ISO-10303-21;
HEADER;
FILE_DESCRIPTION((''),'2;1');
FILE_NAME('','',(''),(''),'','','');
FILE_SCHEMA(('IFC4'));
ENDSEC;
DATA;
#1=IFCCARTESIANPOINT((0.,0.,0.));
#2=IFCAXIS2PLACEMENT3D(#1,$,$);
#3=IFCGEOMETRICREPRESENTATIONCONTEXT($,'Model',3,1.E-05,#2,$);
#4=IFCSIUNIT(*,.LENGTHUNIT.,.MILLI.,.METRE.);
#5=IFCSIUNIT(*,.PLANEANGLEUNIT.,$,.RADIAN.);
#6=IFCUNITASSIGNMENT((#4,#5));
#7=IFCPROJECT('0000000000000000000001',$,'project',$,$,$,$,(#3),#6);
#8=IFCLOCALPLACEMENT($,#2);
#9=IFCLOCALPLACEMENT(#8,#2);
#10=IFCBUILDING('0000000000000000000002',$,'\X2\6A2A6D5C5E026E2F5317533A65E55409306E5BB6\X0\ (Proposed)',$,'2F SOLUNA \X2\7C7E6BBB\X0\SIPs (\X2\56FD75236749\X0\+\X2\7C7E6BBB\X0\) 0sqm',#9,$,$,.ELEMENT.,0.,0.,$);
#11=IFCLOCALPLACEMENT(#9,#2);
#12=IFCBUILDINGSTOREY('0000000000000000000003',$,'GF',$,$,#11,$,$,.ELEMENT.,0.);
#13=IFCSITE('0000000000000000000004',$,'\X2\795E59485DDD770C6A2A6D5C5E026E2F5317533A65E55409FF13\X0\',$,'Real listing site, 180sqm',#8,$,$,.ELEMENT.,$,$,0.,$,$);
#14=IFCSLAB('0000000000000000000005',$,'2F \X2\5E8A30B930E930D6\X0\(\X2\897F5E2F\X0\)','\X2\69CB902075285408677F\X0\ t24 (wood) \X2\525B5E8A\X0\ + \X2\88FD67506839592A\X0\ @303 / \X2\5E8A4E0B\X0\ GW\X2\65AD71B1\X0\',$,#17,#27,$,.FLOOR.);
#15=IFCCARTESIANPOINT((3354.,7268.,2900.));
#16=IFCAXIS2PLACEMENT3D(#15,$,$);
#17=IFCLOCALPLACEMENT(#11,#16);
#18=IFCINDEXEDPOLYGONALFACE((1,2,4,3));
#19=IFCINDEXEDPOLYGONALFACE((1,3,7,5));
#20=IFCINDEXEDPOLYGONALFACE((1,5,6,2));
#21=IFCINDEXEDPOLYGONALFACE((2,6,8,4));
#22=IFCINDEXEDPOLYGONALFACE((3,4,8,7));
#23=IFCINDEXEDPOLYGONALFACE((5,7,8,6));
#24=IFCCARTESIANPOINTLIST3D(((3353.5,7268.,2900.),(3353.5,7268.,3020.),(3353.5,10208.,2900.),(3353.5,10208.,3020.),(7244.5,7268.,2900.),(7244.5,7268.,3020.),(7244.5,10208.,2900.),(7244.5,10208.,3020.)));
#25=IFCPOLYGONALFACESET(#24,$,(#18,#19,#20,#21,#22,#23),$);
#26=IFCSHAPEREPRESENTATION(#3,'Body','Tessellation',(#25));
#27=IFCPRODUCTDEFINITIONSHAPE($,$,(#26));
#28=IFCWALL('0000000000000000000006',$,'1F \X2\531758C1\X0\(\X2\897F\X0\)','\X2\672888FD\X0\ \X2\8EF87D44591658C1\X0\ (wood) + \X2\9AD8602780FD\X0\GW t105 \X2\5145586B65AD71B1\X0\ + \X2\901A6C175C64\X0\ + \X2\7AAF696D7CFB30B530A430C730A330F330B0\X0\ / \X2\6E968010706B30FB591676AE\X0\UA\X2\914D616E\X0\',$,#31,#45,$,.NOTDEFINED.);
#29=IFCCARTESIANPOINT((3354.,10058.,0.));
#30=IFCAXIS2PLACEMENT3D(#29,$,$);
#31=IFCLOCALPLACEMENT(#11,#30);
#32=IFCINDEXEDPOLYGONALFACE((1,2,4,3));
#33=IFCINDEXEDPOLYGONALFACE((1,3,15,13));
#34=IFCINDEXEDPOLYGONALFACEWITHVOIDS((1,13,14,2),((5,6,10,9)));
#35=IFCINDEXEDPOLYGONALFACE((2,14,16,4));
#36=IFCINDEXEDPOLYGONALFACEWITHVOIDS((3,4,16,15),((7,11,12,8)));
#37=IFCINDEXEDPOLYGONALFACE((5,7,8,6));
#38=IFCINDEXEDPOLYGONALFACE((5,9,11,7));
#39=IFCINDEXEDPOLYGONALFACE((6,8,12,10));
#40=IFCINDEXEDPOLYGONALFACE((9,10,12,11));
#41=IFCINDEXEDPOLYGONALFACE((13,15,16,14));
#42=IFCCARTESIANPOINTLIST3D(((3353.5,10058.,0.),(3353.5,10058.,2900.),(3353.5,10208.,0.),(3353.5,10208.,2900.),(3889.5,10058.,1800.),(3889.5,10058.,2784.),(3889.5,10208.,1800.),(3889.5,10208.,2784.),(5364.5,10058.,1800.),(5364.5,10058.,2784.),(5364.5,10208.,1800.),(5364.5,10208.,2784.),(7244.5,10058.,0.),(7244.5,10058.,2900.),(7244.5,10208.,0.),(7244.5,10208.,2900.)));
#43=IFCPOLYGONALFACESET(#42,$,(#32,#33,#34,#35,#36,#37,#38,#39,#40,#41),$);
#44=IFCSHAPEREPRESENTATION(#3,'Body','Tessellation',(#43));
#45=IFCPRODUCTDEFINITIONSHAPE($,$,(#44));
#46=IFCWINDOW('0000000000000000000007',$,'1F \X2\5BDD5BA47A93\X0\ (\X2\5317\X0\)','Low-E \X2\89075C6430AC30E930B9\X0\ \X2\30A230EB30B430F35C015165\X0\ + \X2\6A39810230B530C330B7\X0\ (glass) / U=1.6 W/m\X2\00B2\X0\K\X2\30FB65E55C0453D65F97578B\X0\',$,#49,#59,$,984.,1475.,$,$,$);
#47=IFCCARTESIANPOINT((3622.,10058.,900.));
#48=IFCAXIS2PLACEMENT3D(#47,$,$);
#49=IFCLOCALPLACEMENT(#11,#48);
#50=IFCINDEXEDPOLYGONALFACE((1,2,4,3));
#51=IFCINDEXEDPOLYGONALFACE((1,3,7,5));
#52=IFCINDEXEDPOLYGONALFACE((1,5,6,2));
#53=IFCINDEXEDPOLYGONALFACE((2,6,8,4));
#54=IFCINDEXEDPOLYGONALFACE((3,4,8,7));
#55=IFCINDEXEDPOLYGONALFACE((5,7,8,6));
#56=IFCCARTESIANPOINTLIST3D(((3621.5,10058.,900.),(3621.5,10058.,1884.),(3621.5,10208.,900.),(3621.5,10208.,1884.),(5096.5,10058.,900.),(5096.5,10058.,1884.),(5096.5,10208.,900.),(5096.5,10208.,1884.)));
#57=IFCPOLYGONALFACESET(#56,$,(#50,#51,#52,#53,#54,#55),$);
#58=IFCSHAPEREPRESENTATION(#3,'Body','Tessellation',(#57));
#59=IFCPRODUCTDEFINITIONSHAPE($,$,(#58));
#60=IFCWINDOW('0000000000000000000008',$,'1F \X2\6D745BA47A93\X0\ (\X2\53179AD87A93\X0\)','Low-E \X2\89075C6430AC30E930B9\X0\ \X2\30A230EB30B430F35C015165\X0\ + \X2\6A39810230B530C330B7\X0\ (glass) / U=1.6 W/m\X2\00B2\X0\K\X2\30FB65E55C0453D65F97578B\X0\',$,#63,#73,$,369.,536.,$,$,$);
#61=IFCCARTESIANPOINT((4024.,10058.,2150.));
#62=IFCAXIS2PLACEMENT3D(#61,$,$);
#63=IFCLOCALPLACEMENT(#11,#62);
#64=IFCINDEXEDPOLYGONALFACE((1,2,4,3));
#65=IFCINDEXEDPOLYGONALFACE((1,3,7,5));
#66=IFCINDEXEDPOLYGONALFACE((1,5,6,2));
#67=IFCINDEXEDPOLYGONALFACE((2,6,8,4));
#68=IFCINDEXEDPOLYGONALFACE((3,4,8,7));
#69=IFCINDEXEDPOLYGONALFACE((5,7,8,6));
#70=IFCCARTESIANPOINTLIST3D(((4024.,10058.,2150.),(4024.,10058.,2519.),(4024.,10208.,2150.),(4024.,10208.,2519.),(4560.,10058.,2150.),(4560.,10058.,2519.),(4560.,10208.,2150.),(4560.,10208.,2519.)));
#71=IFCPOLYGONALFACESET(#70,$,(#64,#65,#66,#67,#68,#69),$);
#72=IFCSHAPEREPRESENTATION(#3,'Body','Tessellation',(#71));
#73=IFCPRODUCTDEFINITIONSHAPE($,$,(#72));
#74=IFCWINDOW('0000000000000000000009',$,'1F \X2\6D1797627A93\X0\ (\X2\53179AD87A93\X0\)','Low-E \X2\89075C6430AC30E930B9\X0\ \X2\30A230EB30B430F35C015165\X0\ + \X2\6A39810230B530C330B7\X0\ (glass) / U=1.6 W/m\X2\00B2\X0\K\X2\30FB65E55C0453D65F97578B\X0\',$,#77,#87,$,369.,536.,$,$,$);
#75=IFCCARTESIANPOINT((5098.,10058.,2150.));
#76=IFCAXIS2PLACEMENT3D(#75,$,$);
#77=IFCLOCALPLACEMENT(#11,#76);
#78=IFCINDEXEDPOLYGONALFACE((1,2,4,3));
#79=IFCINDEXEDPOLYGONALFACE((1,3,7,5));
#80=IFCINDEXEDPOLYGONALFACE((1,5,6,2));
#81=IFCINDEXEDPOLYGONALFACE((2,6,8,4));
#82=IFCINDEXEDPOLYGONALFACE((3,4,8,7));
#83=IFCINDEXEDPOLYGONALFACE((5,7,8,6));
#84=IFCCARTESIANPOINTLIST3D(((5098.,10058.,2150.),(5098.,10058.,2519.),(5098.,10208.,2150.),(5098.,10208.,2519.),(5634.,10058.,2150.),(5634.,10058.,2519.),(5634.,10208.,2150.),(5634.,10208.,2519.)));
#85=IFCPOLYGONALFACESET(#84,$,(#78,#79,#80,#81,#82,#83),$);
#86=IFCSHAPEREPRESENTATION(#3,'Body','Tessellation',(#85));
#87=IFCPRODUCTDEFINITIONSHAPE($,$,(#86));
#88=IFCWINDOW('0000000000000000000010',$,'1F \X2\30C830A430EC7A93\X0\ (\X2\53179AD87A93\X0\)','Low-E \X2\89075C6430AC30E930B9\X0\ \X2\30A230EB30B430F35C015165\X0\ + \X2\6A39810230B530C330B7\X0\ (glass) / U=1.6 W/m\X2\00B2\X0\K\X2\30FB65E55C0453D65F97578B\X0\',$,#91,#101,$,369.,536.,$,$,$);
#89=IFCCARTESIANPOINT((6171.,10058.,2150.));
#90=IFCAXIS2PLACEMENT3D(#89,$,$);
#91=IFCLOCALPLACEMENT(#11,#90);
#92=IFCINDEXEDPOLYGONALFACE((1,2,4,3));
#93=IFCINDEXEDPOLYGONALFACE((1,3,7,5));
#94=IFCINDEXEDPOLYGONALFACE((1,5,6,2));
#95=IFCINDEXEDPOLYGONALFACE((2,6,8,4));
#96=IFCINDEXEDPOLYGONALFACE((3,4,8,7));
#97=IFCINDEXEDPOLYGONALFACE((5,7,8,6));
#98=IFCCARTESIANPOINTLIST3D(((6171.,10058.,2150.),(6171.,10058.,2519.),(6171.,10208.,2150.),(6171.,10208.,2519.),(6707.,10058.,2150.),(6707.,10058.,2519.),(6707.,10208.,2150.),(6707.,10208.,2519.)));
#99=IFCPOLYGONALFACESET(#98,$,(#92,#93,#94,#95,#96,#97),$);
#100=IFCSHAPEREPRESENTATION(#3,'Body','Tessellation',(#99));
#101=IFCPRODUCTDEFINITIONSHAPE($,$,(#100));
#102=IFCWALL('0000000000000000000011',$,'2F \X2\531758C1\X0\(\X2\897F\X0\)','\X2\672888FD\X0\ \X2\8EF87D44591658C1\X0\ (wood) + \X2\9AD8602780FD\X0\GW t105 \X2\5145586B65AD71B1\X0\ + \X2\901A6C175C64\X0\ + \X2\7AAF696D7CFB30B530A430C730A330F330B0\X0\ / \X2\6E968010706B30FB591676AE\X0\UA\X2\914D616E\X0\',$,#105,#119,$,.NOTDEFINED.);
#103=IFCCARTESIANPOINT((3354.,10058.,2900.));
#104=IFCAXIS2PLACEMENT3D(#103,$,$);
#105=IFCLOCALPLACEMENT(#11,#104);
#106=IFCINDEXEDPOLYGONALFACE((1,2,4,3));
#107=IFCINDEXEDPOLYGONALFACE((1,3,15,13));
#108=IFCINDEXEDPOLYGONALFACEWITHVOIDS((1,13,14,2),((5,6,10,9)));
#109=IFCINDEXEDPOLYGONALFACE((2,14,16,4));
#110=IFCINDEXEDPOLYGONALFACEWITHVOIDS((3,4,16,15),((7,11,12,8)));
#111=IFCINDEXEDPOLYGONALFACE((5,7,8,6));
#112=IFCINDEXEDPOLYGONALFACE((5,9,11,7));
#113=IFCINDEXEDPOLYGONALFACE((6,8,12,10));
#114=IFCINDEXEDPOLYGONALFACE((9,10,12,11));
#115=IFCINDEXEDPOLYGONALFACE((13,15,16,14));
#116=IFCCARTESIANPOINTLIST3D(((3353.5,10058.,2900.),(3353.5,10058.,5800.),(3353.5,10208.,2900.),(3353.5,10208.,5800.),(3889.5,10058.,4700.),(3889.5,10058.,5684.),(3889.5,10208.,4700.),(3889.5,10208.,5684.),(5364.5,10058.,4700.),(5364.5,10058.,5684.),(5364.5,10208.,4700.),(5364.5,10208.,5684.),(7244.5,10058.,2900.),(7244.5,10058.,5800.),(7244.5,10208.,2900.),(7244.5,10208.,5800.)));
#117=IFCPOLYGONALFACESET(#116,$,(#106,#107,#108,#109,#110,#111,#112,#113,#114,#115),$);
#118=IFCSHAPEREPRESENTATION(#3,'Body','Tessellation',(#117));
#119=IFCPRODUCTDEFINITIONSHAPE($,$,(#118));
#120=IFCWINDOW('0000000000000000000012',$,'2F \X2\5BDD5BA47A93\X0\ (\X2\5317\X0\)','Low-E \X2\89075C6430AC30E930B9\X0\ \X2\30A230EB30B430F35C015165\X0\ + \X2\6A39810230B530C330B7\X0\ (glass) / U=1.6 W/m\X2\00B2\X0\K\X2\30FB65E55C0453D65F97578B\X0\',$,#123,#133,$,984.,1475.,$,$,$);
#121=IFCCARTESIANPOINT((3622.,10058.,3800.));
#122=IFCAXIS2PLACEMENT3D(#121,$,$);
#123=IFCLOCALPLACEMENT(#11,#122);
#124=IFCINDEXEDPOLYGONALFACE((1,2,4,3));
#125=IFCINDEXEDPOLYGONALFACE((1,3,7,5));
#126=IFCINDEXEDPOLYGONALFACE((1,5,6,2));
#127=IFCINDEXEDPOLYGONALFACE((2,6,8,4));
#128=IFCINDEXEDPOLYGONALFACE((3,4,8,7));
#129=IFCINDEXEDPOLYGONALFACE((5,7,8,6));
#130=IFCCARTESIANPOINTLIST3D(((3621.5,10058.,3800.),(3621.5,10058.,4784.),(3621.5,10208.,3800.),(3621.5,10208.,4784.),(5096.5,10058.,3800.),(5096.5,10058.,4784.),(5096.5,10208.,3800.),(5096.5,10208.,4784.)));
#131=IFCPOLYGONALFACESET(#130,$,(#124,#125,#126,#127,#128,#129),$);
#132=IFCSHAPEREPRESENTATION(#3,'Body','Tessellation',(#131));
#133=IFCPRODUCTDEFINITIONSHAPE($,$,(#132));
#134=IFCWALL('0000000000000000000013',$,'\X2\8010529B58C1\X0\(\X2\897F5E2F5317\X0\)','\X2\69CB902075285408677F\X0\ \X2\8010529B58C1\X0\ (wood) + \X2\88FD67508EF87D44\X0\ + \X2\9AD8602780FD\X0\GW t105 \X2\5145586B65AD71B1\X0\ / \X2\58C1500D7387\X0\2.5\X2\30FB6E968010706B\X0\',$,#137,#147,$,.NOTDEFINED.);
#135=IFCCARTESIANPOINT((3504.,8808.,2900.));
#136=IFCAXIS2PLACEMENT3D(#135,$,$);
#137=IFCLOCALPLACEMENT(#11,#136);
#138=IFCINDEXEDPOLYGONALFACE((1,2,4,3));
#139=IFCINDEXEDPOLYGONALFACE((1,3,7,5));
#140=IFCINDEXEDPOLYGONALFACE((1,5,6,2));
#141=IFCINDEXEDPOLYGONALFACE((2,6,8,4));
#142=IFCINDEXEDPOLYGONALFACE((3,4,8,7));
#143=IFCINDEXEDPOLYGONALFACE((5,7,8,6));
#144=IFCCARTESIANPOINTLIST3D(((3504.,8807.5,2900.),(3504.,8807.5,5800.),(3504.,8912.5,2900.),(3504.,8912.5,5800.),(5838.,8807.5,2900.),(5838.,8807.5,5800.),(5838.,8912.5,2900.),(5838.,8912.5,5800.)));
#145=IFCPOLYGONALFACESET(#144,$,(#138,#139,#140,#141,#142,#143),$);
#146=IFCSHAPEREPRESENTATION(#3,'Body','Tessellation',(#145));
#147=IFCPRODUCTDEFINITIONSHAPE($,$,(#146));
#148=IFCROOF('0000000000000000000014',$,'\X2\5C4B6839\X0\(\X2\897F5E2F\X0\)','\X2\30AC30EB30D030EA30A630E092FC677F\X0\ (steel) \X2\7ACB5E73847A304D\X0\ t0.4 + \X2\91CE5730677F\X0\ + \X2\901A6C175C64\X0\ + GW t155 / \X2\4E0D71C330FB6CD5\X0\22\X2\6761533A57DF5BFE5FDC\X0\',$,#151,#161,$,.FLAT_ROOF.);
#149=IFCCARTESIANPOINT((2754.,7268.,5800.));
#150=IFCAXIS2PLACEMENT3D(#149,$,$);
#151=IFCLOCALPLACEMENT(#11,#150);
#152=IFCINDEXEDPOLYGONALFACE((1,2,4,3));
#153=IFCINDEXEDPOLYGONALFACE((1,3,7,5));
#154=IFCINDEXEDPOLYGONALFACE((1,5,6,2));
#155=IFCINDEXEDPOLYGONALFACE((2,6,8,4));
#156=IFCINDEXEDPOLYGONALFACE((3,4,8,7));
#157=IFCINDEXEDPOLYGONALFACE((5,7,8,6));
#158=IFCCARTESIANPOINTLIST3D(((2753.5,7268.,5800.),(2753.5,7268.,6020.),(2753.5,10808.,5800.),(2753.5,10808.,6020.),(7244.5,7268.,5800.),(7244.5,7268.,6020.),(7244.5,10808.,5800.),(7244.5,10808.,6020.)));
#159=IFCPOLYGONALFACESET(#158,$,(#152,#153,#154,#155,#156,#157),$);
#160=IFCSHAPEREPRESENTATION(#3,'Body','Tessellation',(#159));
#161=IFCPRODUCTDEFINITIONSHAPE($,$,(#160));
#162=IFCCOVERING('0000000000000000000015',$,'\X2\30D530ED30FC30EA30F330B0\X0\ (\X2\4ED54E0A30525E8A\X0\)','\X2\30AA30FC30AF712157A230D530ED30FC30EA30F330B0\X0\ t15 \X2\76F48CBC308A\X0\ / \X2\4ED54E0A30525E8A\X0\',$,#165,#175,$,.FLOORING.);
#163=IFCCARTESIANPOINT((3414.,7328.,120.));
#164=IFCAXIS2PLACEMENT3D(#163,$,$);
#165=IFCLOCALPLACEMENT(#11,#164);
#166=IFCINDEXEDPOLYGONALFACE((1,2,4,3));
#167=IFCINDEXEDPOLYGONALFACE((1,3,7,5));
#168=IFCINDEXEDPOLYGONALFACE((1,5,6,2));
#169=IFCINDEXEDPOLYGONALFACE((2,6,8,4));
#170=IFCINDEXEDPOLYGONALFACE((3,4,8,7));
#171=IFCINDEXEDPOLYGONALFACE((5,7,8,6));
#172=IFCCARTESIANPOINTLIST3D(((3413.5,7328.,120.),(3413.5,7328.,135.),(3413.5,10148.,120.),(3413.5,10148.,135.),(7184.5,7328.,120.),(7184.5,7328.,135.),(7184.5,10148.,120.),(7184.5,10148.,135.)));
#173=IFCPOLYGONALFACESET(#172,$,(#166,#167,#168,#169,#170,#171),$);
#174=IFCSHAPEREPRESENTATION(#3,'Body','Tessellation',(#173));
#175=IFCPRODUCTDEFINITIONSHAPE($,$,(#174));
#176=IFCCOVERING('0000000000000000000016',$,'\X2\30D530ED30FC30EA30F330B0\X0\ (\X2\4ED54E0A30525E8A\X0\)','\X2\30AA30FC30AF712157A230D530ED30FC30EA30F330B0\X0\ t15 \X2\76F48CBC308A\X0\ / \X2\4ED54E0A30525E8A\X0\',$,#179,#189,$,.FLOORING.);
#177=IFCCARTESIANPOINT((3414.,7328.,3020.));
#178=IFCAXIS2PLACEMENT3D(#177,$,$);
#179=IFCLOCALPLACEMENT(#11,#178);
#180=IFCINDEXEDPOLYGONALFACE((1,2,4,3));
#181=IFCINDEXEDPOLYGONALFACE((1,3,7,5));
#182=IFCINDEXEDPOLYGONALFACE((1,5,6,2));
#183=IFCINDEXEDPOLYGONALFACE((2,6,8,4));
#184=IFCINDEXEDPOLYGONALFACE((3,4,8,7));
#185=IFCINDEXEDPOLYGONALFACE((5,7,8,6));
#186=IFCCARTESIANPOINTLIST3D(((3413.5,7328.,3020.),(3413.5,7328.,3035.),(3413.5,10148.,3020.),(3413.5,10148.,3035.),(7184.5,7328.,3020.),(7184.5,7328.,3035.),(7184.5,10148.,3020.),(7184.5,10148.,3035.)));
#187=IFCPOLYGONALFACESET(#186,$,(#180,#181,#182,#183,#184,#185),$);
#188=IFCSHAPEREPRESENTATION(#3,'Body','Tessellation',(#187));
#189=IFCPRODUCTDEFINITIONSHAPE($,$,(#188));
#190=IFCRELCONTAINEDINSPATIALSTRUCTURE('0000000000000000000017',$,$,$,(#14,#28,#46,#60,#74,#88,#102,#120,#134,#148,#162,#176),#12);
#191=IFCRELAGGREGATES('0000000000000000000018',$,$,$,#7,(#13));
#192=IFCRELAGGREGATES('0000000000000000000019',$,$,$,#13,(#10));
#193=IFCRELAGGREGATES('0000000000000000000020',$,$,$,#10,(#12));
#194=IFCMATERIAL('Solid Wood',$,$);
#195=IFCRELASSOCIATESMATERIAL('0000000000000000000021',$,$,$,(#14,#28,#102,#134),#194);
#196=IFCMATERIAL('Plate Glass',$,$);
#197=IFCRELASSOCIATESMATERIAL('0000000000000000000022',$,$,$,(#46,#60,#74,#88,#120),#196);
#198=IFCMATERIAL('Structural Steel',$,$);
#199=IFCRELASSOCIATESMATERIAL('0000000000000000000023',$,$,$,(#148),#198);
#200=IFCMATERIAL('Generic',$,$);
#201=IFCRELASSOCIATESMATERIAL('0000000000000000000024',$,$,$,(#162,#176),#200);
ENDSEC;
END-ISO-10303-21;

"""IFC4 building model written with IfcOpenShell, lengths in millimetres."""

from ifc_helpers import new_model, si_unit, frame, frame_2d, origin, place, context, project, spatial, rectangle, extrude, material, element, fill, save


model = new_model("IFC4")

# Units and contexts
model_context = context("Model", 3, precision=1e-05, world=origin())
ifc_project = project(units=[si_unit("LENGTHUNIT", "METRE", prefix="MILLI"), si_unit("PLANEANGLEUNIT", "RADIAN")], contexts=[model_context])

# Site, building, storey
site_placement = place(None, origin())
site = spatial("IfcSite", under=ifc_project, at=site_placement, Name="神奈川県横浜市港北区日吉３", ObjectType="Real listing site, 180sqm", CompositionType="ELEMENT", RefElevation=0.0)
building_placement = place(site_placement, origin())
building = spatial("IfcBuilding", under=site, at=building_placement, Name="横浜市港北区日吉の家 (Proposed)", ObjectType="2F SOLUNA 籾殻SIPs (国産杉+籾殻) 0sqm", CompositionType="ELEMENT", ElevationOfRefHeight=0.0, ElevationOfTerrain=0.0)
storey_placement = place(building_placement, origin())
storey = spatial("IfcBuildingStorey", under=building, at=storey_placement, Name="GF", CompositionType="ELEMENT", Elevation=0.0)

# Slab
ifc_material_1 = material(Name="Solid Wood")
slab_1_placement = place(storey_placement, frame((3354.0, 7268.0, 2900.0)))
element("IfcSlab", 1, at=slab_1_placement, inside=storey, material=ifc_material_1, Name="2F 床スラブ(西帯)", Description="構造用合板 t24 (wood) 剛床 + 製材根太 @303 / 床下 GW断熱", PredefinedType="FLOOR", context=model_context, shape_type="SweptSolid", body=[
    extrude(rectangle(XDim=3891.0, YDim=2940.0, at=frame_2d((1945.0, 1470.0))), frame((3354.0, 7268.0, 2900.0)), (0.0, 0.0, 1.0), 120.0),
])

# Wall, openings, windows
wall_1_placement = place(storey_placement, frame((3354.0, 10058.0, 0.0)))
wall_1 = element("IfcWall", 2, at=wall_1_placement, inside=storey, material=ifc_material_1, Name="1F 北壁(西)", Description="木製 軸組外壁 (wood) + 高性能GW t105 充填断熱 + 通気層 + 窯業系サイディング / 準耐火・外皮UA配慮", PredefinedType="NOTDEFINED", context=model_context, shape_type="SweptSolid", body=[
    extrude(rectangle(XDim=3891.0, YDim=150.0, at=frame_2d((1945.0, 75.0))), frame((3354.0, 10058.0, 0.0)), (0.0, 0.0, 1.0), 2900.0),
])
opening_1_placement = place(storey_placement, frame((3622.0, 10058.0, 900.0)))
opening_1 = element("IfcOpeningElement", 3, at=opening_1_placement, cuts=wall_1, PredefinedType="NOTDEFINED", context=model_context, shape_type="SweptSolid", body=[
    extrude(rectangle(XDim=1475.0, YDim=150.0, at=frame_2d((737.0, 75.0))), frame((3622.0, 10058.0, 900.0)), (0.0, 0.0, 1.0), 984.0),
])
opening_2_placement = place(storey_placement, frame((4024.0, 10058.0, 2150.0)))
opening_2 = element("IfcOpeningElement", 4, at=opening_2_placement, cuts=wall_1, PredefinedType="NOTDEFINED", context=model_context, shape_type="SweptSolid", body=[
    extrude(rectangle(XDim=536.0, YDim=150.0, at=frame_2d((268.0, 75.0))), frame((4024.0, 10058.0, 2150.0)), (0.0, 0.0, 1.0), 369.0),
])
opening_3_placement = place(storey_placement, frame((5098.0, 10058.0, 2150.0)))
opening_3 = element("IfcOpeningElement", 5, at=opening_3_placement, cuts=wall_1, PredefinedType="NOTDEFINED", context=model_context, shape_type="SweptSolid", body=[
    extrude(rectangle(XDim=536.0, YDim=150.0, at=frame_2d((268.0, 75.0))), frame((5098.0, 10058.0, 2150.0)), (0.0, 0.0, 1.0), 369.0),
])
opening_4_placement = place(storey_placement, frame((6171.0, 10058.0, 2150.0)))
opening_4 = element("IfcOpeningElement", 6, at=opening_4_placement, cuts=wall_1, PredefinedType="NOTDEFINED", context=model_context, shape_type="SweptSolid", body=[
    extrude(rectangle(XDim=536.0, YDim=150.0, at=frame_2d((268.0, 75.0))), frame((6171.0, 10058.0, 2150.0)), (0.0, 0.0, 1.0), 369.0),
])
ifc_material_2 = material(Name="Plate Glass")
window_1_placement = place(storey_placement, frame((3622.0, 10058.0, 900.0)))
window_1 = element("IfcWindow", 7, at=window_1_placement, inside=storey, material=ifc_material_2, Name="1F 寝室窓 (北)", Description="Low-E 複層ガラス アルゴン封入 + 樹脂サッシ (glass) / U=1.6 W/m²K・日射取得型", OverallHeight=984.0, OverallWidth=1475.0, context=model_context, shape_type="SweptSolid", body=[
    extrude(rectangle(XDim=1475.0, YDim=150.0, at=frame_2d((737.0, 75.0))), frame((3622.0, 10058.0, 900.0)), (0.0, 0.0, 1.0), 984.0),
])
fill(opening_1, window_1)
window_2_placement = place(storey_placement, frame((4024.0, 10058.0, 2150.0)))
window_2 = element("IfcWindow", 8, at=window_2_placement, inside=storey, material=ifc_material_2, Name="1F 浴室窓 (北高窓)", Description="Low-E 複層ガラス アルゴン封入 + 樹脂サッシ (glass) / U=1.6 W/m²K・日射取得型", OverallHeight=369.0, OverallWidth=536.0, context=model_context, shape_type="SweptSolid", body=[
    extrude(rectangle(XDim=536.0, YDim=150.0, at=frame_2d((268.0, 75.0))), frame((4024.0, 10058.0, 2150.0)), (0.0, 0.0, 1.0), 369.0),
])
fill(opening_2, window_2)
window_3_placement = place(storey_placement, frame((5098.0, 10058.0, 2150.0)))
window_3 = element("IfcWindow", 9, at=window_3_placement, inside=storey, material=ifc_material_2, Name="1F 洗面窓 (北高窓)", Description="Low-E 複層ガラス アルゴン封入 + 樹脂サッシ (glass) / U=1.6 W/m²K・日射取得型", OverallHeight=369.0, OverallWidth=536.0, context=model_context, shape_type="SweptSolid", body=[
    extrude(rectangle(XDim=536.0, YDim=150.0, at=frame_2d((268.0, 75.0))), frame((5098.0, 10058.0, 2150.0)), (0.0, 0.0, 1.0), 369.0),
])
fill(opening_3, window_3)
window_4_placement = place(storey_placement, frame((6171.0, 10058.0, 2150.0)))
window_4 = element("IfcWindow", 10, at=window_4_placement, inside=storey, material=ifc_material_2, Name="1F トイレ窓 (北高窓)", Description="Low-E 複層ガラス アルゴン封入 + 樹脂サッシ (glass) / U=1.6 W/m²K・日射取得型", OverallHeight=369.0, OverallWidth=536.0, context=model_context, shape_type="SweptSolid", body=[
    extrude(rectangle(XDim=536.0, YDim=150.0, at=frame_2d((268.0, 75.0))), frame((6171.0, 10058.0, 2150.0)), (0.0, 0.0, 1.0), 369.0),
])
fill(opening_4, window_4)

# Wall, opening, window
wall_2_placement = place(storey_placement, frame((3354.0, 10058.0, 2900.0)))
wall_2 = element("IfcWall", 11, at=wall_2_placement, inside=storey, material=ifc_material_1, Name="2F 北壁(西)", Description="木製 軸組外壁 (wood) + 高性能GW t105 充填断熱 + 通気層 + 窯業系サイディング / 準耐火・外皮UA配慮", PredefinedType="NOTDEFINED", context=model_context, shape_type="SweptSolid", body=[
    extrude(rectangle(XDim=3891.0, YDim=150.0, at=frame_2d((1945.0, 75.0))), frame((3354.0, 10058.0, 2900.0)), (0.0, 0.0, 1.0), 2900.0),
])
opening_5_placement = place(storey_placement, frame((3622.0, 10058.0, 3800.0)))
opening_5 = element("IfcOpeningElement", 12, at=opening_5_placement, cuts=wall_2, PredefinedType="NOTDEFINED", context=model_context, shape_type="SweptSolid", body=[
    extrude(rectangle(XDim=1475.0, YDim=150.0, at=frame_2d((737.0, 75.0))), frame((3622.0, 10058.0, 3800.0)), (0.0, 0.0, 1.0), 984.0),
])
window_5_placement = place(storey_placement, frame((3622.0, 10058.0, 3800.0)))
window_5 = element("IfcWindow", 13, at=window_5_placement, inside=storey, material=ifc_material_2, Name="2F 寝室窓 (北)", Description="Low-E 複層ガラス アルゴン封入 + 樹脂サッシ (glass) / U=1.6 W/m²K・日射取得型", OverallHeight=984.0, OverallWidth=1475.0, context=model_context, shape_type="SweptSolid", body=[
    extrude(rectangle(XDim=1475.0, YDim=150.0, at=frame_2d((737.0, 75.0))), frame((3622.0, 10058.0, 3800.0)), (0.0, 0.0, 1.0), 984.0),
])
fill(opening_5, window_5)

# Wall
wall_3_placement = place(storey_placement, frame((3504.0, 8808.0, 2900.0)))
element("IfcWall", 14, at=wall_3_placement, inside=storey, material=ifc_material_1, Name="耐力壁(西帯北)", Description="構造用合板 耐力壁 (wood) + 製材軸組 + 高性能GW t105 充填断熱 / 壁倍率2.5・準耐火", PredefinedType="NOTDEFINED", context=model_context, shape_type="SweptSolid", body=[
    extrude(rectangle(XDim=2334.0, YDim=105.0, at=frame_2d((1167.0, 52.0))), frame((3504.0, 8808.0, 2900.0)), (0.0, 0.0, 1.0), 2900.0),
])

# Roof
ifc_material_3 = material(Name="Structural Steel")
for number, where, name in (
    (15, (2754.0, 7268.0, 5800.0), "屋根(西帯)"),
):
    element("IfcRoof", number, at=place(storey_placement, frame(where)), inside=storey, material=ifc_material_3, Name=name, Description="ガルバリウム鋼板 (steel) 立平葺き t0.4 + 野地板 + 通気層 + GW t155 / 不燃・法22条区域対応", PredefinedType="FLAT_ROOF", context=model_context, shape_type="SweptSolid", body=[
        extrude(rectangle(XDim=4491.0, YDim=3540.0, at=frame_2d((2245.0, 1770.0))), frame((2754.0, 7268.0, 5800.0)), (0.0, 0.0, 1.0), 220.0),
    ])

# Coverings
ifc_material_4 = material(Name="Generic")
covering_1_placement = place(storey_placement, frame((3414.0, 7328.0, 120.0)))
element("IfcCovering", 16, at=covering_1_placement, inside=storey, material=ifc_material_4, Name="フローリング (仕上げ床)", Description="オーク無垢フローリング t15 直貼り / 仕上げ床", PredefinedType="FLOORING", context=model_context, shape_type="SweptSolid", body=[
    extrude(rectangle(XDim=3771.0, YDim=2820.0, at=frame_2d((1885.0, 1410.0))), frame((3414.0, 7328.0, 120.0)), (0.0, 0.0, 1.0), 15.0),
])
covering_2_placement = place(storey_placement, frame((3414.0, 7328.0, 3020.0)))
element("IfcCovering", 17, at=covering_2_placement, inside=storey, material=ifc_material_4, Name="フローリング (仕上げ床)", Description="オーク無垢フローリング t15 直貼り / 仕上げ床", PredefinedType="FLOORING", context=model_context, shape_type="SweptSolid", body=[
    extrude(rectangle(XDim=3771.0, YDim=2820.0, at=frame_2d((1885.0, 1410.0))), frame((3414.0, 7328.0, 3020.0)), (0.0, 0.0, 1.0), 15.0),
])

save(model, "model.ifc")
